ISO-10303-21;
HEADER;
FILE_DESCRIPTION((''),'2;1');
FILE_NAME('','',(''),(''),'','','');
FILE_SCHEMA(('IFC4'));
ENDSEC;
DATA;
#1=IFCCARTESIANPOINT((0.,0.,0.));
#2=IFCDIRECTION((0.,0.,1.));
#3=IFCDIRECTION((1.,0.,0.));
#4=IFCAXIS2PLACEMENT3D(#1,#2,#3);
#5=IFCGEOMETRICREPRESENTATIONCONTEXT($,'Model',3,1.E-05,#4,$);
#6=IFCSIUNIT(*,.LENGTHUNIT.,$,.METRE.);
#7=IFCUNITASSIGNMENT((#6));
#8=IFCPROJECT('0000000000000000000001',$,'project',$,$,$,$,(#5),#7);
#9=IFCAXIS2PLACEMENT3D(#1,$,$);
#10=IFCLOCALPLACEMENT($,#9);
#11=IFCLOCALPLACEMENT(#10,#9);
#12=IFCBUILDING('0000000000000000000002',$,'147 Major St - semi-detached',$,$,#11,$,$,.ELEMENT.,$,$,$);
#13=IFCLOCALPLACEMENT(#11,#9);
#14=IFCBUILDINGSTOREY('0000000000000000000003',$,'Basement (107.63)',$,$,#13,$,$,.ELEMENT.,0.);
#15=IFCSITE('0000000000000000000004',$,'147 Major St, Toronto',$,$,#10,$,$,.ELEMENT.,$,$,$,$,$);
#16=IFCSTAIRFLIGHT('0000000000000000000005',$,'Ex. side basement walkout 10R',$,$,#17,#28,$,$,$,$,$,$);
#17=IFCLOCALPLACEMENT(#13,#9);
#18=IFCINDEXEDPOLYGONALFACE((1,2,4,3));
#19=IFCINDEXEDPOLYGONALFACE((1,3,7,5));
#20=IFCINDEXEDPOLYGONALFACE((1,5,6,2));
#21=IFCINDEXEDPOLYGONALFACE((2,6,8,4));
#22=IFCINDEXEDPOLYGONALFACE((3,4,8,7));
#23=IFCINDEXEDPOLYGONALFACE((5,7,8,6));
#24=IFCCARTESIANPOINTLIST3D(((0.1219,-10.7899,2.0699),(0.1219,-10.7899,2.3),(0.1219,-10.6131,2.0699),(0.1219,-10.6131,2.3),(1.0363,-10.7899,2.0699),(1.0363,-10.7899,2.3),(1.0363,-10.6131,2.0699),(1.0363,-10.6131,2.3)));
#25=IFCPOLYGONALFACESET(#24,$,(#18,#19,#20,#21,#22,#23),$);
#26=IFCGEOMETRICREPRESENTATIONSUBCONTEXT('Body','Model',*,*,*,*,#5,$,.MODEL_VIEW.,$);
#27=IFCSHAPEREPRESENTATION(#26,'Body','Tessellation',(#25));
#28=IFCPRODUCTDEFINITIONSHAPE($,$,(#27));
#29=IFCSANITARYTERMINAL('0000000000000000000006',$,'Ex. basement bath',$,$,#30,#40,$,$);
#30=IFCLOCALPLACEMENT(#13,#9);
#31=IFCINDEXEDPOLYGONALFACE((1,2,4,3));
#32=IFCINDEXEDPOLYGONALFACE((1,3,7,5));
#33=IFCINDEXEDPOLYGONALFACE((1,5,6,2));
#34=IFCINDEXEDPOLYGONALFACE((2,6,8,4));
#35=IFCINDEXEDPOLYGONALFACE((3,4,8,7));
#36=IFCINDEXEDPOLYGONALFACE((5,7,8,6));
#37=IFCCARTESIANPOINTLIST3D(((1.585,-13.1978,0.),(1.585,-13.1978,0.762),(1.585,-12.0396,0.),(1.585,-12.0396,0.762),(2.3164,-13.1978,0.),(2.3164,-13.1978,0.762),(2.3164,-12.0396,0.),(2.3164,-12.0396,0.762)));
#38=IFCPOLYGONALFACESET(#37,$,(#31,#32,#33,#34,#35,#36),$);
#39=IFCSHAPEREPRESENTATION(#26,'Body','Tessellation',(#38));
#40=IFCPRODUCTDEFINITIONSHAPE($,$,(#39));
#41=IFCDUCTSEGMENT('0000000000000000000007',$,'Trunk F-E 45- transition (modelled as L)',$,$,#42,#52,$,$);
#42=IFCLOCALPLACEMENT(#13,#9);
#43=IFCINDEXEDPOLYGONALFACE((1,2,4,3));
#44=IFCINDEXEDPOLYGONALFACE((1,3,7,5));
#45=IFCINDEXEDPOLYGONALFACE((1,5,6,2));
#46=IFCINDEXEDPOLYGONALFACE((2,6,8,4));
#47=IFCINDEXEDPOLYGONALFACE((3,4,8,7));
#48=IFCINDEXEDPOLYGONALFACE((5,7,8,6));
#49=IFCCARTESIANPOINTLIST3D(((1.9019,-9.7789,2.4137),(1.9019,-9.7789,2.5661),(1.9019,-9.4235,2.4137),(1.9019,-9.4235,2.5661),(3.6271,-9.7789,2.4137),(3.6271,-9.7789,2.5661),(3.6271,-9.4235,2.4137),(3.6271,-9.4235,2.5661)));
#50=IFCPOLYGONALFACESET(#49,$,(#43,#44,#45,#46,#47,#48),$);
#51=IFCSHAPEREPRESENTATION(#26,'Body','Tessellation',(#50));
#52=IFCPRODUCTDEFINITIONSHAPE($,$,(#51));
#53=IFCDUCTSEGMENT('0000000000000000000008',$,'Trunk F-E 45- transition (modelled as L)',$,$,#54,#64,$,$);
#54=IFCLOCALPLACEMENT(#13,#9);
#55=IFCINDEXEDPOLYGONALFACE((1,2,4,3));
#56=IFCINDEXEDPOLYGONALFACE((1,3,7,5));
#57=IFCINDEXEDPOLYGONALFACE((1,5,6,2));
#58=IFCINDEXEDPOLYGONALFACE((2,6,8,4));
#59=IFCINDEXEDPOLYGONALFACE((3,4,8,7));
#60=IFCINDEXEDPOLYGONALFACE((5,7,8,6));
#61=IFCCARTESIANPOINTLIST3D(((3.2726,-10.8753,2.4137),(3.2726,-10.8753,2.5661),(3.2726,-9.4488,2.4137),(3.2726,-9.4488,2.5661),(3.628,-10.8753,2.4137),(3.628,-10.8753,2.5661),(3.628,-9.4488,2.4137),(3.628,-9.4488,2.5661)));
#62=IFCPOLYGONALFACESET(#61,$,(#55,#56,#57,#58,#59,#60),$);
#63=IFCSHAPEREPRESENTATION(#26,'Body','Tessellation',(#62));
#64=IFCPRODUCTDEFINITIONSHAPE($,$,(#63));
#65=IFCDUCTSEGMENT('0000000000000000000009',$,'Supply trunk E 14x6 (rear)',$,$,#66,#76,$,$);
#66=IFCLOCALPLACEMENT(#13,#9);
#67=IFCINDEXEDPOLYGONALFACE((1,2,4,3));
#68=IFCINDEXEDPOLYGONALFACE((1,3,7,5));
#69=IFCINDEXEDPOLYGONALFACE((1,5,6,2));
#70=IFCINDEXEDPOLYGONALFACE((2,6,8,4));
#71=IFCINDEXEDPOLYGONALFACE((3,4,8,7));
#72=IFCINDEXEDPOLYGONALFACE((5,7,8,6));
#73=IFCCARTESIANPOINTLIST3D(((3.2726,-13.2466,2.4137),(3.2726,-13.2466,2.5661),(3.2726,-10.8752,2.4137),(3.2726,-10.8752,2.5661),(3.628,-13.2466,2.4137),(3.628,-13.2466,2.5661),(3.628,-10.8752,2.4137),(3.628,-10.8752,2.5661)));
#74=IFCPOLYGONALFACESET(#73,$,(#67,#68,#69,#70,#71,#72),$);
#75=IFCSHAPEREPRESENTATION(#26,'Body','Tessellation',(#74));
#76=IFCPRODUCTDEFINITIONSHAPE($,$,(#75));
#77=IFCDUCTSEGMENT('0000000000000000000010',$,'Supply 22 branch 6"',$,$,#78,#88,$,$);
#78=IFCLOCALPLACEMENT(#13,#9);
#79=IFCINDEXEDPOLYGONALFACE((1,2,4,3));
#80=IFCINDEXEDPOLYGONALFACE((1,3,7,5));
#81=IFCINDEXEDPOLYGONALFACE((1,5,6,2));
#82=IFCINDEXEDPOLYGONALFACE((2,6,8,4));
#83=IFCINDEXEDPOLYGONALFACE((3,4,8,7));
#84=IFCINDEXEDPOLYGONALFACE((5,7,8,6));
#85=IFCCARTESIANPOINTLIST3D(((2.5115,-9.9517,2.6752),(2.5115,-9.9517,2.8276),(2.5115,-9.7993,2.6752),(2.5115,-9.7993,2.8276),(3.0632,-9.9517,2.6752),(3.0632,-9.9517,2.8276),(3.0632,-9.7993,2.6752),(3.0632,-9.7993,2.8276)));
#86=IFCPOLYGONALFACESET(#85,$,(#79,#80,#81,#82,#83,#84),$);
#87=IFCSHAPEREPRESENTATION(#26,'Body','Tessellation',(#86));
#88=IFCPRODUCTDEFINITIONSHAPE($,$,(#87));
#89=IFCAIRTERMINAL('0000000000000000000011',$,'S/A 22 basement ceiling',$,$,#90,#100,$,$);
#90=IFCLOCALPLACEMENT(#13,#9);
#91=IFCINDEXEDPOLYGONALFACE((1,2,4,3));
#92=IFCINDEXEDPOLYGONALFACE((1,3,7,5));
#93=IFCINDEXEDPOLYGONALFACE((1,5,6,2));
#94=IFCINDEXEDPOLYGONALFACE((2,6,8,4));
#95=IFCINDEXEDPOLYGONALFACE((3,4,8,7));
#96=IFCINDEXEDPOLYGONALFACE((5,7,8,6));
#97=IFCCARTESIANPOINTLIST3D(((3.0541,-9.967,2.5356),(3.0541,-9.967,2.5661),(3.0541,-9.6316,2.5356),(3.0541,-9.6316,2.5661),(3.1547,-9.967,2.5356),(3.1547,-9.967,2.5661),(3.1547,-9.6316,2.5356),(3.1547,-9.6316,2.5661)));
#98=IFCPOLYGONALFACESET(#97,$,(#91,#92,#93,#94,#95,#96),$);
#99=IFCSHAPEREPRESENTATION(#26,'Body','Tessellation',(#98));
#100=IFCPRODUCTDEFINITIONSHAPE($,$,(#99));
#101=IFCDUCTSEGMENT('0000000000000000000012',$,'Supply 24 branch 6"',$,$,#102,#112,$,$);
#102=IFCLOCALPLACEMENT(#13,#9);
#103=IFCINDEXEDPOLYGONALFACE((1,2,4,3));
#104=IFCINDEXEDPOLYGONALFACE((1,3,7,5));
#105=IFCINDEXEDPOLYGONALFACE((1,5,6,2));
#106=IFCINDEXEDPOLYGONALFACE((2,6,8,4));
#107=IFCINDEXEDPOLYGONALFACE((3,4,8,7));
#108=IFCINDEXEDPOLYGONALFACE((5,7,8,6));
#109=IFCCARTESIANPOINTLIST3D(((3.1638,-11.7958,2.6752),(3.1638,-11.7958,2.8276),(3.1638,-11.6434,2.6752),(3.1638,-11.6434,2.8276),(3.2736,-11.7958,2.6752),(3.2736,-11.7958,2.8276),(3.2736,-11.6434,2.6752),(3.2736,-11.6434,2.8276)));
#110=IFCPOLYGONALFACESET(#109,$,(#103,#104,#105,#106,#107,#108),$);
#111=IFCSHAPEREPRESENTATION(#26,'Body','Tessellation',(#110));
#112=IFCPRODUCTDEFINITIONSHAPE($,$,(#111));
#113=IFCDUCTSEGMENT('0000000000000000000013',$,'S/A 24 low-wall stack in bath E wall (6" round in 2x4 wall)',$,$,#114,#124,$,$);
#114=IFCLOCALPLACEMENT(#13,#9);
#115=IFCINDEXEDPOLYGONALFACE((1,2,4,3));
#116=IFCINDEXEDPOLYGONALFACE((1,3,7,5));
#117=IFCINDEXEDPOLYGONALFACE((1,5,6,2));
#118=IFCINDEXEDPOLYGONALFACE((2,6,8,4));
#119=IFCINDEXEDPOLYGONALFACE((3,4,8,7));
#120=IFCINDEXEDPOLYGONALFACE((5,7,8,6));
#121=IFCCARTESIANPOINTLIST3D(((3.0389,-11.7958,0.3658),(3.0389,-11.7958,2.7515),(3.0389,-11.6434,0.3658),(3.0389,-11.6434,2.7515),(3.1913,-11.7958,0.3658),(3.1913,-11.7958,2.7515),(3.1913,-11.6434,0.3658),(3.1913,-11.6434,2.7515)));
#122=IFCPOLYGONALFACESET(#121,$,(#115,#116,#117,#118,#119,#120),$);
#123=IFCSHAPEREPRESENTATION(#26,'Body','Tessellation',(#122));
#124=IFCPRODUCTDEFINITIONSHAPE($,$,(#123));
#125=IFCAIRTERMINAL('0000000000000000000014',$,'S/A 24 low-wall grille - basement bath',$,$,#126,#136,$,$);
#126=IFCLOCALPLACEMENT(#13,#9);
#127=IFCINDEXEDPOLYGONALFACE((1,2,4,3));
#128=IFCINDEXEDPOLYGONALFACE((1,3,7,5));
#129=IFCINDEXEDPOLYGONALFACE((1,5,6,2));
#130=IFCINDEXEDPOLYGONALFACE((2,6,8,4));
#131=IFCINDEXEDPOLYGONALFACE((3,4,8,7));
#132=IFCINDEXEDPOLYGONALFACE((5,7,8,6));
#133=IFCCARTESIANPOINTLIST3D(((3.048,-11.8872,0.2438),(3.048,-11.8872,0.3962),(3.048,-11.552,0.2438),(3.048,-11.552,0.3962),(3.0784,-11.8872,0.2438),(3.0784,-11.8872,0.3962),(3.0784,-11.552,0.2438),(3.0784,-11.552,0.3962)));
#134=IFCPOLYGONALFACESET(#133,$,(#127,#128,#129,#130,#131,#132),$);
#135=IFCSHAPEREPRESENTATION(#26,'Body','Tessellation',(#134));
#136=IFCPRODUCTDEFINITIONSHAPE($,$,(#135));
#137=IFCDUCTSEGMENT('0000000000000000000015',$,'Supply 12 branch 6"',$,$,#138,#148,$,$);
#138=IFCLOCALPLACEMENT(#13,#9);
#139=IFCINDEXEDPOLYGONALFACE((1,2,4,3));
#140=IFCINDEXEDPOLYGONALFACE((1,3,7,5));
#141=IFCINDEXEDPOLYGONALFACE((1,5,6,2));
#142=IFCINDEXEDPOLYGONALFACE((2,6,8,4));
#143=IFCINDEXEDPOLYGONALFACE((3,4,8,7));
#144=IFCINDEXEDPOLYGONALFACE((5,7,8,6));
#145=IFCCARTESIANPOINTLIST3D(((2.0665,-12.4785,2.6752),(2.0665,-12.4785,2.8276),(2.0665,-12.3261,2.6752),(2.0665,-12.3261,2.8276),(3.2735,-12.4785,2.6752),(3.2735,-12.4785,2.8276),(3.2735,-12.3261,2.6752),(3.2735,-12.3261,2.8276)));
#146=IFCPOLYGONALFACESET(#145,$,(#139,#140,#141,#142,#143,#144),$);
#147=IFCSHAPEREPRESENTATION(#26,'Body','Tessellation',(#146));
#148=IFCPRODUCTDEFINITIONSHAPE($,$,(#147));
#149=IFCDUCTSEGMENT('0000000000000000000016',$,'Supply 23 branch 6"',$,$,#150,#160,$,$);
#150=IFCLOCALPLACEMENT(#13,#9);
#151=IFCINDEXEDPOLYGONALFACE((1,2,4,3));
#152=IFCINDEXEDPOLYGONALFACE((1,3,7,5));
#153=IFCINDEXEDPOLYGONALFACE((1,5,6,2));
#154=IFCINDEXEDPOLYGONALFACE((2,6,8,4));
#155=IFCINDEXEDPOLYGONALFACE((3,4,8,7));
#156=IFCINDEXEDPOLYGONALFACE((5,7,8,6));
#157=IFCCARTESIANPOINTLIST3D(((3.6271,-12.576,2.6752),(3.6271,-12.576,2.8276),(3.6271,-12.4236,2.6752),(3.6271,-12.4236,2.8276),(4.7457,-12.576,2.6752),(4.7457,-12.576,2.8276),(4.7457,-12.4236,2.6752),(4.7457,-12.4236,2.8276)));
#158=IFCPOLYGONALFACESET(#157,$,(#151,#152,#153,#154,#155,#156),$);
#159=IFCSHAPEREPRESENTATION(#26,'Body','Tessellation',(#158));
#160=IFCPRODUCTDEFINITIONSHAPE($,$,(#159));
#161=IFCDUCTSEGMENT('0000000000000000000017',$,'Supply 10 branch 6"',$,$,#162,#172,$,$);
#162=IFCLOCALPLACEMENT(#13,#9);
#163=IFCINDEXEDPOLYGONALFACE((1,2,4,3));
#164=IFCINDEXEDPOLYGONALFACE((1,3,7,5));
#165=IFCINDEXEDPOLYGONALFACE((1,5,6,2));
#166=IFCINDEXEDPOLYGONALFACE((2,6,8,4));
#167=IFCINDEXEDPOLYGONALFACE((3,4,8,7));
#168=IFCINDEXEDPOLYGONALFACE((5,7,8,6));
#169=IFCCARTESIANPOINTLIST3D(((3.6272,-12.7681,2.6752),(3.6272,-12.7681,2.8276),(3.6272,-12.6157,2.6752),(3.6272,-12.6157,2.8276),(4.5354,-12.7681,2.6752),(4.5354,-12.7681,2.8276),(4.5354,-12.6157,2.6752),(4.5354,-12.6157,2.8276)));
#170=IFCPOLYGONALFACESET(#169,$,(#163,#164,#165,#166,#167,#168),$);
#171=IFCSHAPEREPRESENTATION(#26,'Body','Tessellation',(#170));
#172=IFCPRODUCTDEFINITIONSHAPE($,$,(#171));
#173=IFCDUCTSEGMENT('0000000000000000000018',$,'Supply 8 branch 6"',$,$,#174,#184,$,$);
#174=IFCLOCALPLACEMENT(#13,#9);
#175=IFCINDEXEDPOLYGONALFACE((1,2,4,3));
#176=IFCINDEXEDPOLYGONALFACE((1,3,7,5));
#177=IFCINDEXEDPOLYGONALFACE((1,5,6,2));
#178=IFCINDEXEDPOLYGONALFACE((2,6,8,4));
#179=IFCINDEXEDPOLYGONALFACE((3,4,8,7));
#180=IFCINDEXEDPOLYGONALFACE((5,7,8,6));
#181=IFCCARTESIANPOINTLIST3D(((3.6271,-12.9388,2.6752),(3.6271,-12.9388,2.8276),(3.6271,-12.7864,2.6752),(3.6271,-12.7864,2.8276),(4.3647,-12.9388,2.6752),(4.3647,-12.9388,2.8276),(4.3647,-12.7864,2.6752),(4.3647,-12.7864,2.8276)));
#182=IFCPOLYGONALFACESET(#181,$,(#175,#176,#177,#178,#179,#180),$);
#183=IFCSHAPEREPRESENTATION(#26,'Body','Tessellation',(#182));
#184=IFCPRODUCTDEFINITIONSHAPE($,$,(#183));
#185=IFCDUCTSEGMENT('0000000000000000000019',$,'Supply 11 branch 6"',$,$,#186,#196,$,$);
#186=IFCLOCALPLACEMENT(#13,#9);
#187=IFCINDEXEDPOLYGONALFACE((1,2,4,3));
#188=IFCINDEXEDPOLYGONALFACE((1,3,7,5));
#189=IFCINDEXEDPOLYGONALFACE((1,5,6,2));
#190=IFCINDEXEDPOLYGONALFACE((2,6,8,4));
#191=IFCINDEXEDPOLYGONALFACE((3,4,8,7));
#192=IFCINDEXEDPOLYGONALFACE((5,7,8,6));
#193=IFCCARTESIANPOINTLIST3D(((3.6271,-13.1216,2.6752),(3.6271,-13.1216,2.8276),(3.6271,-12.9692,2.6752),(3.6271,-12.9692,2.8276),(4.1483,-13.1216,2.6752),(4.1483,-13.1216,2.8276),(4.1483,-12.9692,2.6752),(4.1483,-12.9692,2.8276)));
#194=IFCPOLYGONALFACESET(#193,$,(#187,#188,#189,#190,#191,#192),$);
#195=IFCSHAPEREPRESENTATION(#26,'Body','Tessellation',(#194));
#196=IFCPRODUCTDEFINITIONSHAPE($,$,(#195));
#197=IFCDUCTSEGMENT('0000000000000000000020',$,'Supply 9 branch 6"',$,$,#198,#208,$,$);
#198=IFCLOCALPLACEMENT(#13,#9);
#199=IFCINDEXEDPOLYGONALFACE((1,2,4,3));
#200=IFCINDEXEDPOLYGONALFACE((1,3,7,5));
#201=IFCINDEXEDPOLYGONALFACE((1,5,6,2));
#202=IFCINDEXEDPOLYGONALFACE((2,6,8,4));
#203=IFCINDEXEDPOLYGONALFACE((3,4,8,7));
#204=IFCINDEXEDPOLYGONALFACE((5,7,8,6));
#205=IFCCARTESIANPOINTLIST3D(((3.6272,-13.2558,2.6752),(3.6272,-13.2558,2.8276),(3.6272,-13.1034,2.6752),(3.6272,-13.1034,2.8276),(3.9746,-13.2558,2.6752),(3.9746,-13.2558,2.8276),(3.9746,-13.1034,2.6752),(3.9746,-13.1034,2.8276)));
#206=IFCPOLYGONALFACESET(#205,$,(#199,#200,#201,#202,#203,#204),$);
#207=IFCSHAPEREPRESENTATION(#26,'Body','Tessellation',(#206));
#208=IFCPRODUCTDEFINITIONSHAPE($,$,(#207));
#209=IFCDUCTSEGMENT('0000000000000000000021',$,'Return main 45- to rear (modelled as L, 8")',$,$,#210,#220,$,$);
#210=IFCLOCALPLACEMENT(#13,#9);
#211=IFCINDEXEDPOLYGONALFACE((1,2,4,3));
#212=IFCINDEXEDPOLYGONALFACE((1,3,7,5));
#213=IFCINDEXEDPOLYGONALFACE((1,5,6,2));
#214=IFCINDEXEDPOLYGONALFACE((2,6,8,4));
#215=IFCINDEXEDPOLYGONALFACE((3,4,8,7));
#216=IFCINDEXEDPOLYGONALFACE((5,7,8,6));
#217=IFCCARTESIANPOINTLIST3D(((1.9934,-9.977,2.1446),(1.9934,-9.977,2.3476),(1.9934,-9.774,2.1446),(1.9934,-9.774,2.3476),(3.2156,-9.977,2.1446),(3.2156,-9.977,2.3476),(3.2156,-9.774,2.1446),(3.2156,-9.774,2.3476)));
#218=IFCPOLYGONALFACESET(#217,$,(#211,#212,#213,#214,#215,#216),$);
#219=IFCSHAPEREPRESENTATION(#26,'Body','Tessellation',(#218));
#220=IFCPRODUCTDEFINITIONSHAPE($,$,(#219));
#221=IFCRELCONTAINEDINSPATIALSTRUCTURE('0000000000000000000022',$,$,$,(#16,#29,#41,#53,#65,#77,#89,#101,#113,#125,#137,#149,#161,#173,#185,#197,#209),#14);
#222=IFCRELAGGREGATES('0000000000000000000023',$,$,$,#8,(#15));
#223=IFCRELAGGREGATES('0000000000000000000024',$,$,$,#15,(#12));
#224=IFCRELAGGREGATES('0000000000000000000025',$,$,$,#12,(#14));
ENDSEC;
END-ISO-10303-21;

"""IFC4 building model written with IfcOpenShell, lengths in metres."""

from ifc_helpers import new_model, si_unit, frame, origin, origin_with_axes, place, context, subcontext, project, spatial, rectangle, extrude, element, save


model = new_model("IFC4")

# Units and contexts
model_context = context("Model", 3, precision=1e-05, world=origin_with_axes())
body_context = subcontext(model_context, "Body", "Model", "MODEL_VIEW")
ifc_project = project(units=[si_unit("LENGTHUNIT", "METRE")], contexts=[model_context])

# Site, building, storey
site_placement = place(None, origin())
site = spatial("IfcSite", under=ifc_project, at=site_placement, Name="147 Major St, Toronto", CompositionType="ELEMENT")
building_placement = place(site_placement, origin())
building = spatial("IfcBuilding", under=site, at=building_placement, Name="147 Major St - semi-detached", CompositionType="ELEMENT")
storey_placement = place(building_placement, origin())
storey = spatial("IfcBuildingStorey", under=building, at=storey_placement, Name="Basement (107.63)", CompositionType="ELEMENT", Elevation=0.0)

# Stair flight
stair_flight_1_placement = place(storey_placement, frame((0.5791, -10.7015, 2.0699)))
element("IfcStairFlight", 1, at=stair_flight_1_placement, inside=storey, Name="Ex. side basement walkout 10R", context=body_context, shape_type="SweptSolid", body=[
    extrude(rectangle(XDim=0.9144, YDim=0.1768), origin_with_axes(), (0.0, 0.0, 1.0), 0.2301),
])

# Sanitary terminal
sanitary_terminal_placement = place(storey_placement, frame((1.9507, -12.6187, 0.0)))
element("IfcSanitaryTerminal", 2, at=sanitary_terminal_placement, inside=storey, Name="Ex. basement bath", context=body_context, shape_type="SweptSolid", body=[
    extrude(rectangle(XDim=0.7315, YDim=1.1582), origin_with_axes(), (0.0, 0.0, 1.0), 0.762),
])

# Duct segments
duct_segment_1_placement = place(storey_placement, frame((2.7645, -9.6012, 2.4137)))
element("IfcDuctSegment", 3, at=duct_segment_1_placement, inside=storey, Name="Trunk F-E 45- transition (modelled as L)", context=body_context, shape_type="SweptSolid", body=[
    extrude(rectangle(XDim=1.7252, YDim=0.3554), origin_with_axes(), (0.0, 0.0, 1.0), 0.1524),
])
duct_segment_2_placement = place(storey_placement, frame((3.4503, -10.162, 2.4137)))
element("IfcDuctSegment", 4, at=duct_segment_2_placement, inside=storey, Name="Trunk F-E 45- transition (modelled as L)", context=body_context, shape_type="SweptSolid", body=[
    extrude(rectangle(XDim=0.3554, YDim=1.4265), origin_with_axes(), (0.0, 0.0, 1.0), 0.1524),
])
duct_segment_3_placement = place(storey_placement, frame((3.4503, -12.0609, 2.4137)))
element("IfcDuctSegment", 5, at=duct_segment_3_placement, inside=storey, Name="Supply trunk E 14x6 (rear)", context=body_context, shape_type="SweptSolid", body=[
    extrude(rectangle(XDim=0.3554, YDim=2.3713), origin_with_axes(), (0.0, 0.0, 1.0), 0.1524),
])
duct_segment_4_placement = place(storey_placement, frame((2.7874, -9.8755, 2.6752)))
element("IfcDuctSegment", 6, at=duct_segment_4_placement, inside=storey, Name="Supply 22 branch 6\"", context=body_context, shape_type="SweptSolid", body=[
    extrude(rectangle(XDim=0.5517, YDim=0.1524), origin_with_axes(), (0.0, 0.0, 1.0), 0.1524),
])

# Air terminal
air_terminal_1_placement = place(storey_placement, frame((3.1044, -9.7993, 2.5356)))
element("IfcAirTerminal", 7, at=air_terminal_1_placement, inside=storey, Name="S/A 22 basement ceiling", context=body_context, shape_type="SweptSolid", body=[
    extrude(rectangle(XDim=0.1006, YDim=0.3353), origin_with_axes(), (0.0, 0.0, 1.0), 0.0305),
])

# Duct segments
duct_segment_5_placement = place(storey_placement, frame((3.2187, -11.7196, 2.6752)))
element("IfcDuctSegment", 8, at=duct_segment_5_placement, inside=storey, Name="Supply 24 branch 6\"", context=body_context, shape_type="SweptSolid", body=[
    extrude(rectangle(XDim=0.1097, YDim=0.1524), origin_with_axes(), (0.0, 0.0, 1.0), 0.1524),
])
duct_segment_6_placement = place(storey_placement, frame((3.1151, -11.7196, 0.3658)))
element("IfcDuctSegment", 9, at=duct_segment_6_placement, inside=storey, Name="S/A 24 low-wall stack in bath E wall (6\" round in 2x4 wall)", context=body_context, shape_type="SweptSolid", body=[
    extrude(rectangle(XDim=0.1524, YDim=0.1524), origin_with_axes(), (0.0, 0.0, 1.0), 2.3857),
])

# Air terminal
air_terminal_2_placement = place(storey_placement, frame((3.0632, -11.7196, 0.2438)))
element("IfcAirTerminal", 10, at=air_terminal_2_placement, inside=storey, Name="S/A 24 low-wall grille - basement bath", context=body_context, shape_type="SweptSolid", body=[
    extrude(rectangle(XDim=0.0305, YDim=0.3353), origin_with_axes(), (0.0, 0.0, 1.0), 0.1524),
])

# Duct segments
duct_segment_7_placement = place(storey_placement, frame((2.67, -12.4023, 2.6752)))
element("IfcDuctSegment", 11, at=duct_segment_7_placement, inside=storey, Name="Supply 12 branch 6\"", context=body_context, shape_type="SweptSolid", body=[
    extrude(rectangle(XDim=1.207, YDim=0.1524), origin_with_axes(), (0.0, 0.0, 1.0), 0.1524),
])
duct_segment_8_placement = place(storey_placement, frame((4.1864, -12.4998, 2.6752)))
element("IfcDuctSegment", 12, at=duct_segment_8_placement, inside=storey, Name="Supply 23 branch 6\"", context=body_context, shape_type="SweptSolid", body=[
    extrude(rectangle(XDim=1.1186, YDim=0.1524), origin_with_axes(), (0.0, 0.0, 1.0), 0.1524),
])
duct_segment_9_placement = place(storey_placement, frame((4.0813, -12.6919, 2.6752)))
element("IfcDuctSegment", 13, at=duct_segment_9_placement, inside=storey, Name="Supply 10 branch 6\"", context=body_context, shape_type="SweptSolid", body=[
    extrude(rectangle(XDim=0.9083, YDim=0.1524), origin_with_axes(), (0.0, 0.0, 1.0), 0.1524),
])
duct_segment_10_placement = place(storey_placement, frame((3.9959, -12.8626, 2.6752)))
element("IfcDuctSegment", 14, at=duct_segment_10_placement, inside=storey, Name="Supply 8 branch 6\"", context=body_context, shape_type="SweptSolid", body=[
    extrude(rectangle(XDim=0.7376, YDim=0.1524), origin_with_axes(), (0.0, 0.0, 1.0), 0.1524),
])
duct_segment_11_placement = place(storey_placement, frame((3.8877, -13.0454, 2.6752)))
element("IfcDuctSegment", 15, at=duct_segment_11_placement, inside=storey, Name="Supply 11 branch 6\"", context=body_context, shape_type="SweptSolid", body=[
    extrude(rectangle(XDim=0.5212, YDim=0.1524), origin_with_axes(), (0.0, 0.0, 1.0), 0.1524),
])
duct_segment_12_placement = place(storey_placement, frame((3.8009, -13.1796, 2.6752)))
element("IfcDuctSegment", 16, at=duct_segment_12_placement, inside=storey, Name="Supply 9 branch 6\"", context=body_context, shape_type="SweptSolid", body=[
    extrude(rectangle(XDim=0.3475, YDim=0.1524), origin_with_axes(), (0.0, 0.0, 1.0), 0.1524),
])
duct_segment_13_placement = place(storey_placement, frame((2.6045, -9.8755, 2.1446)))
element("IfcDuctSegment", 17, at=duct_segment_13_placement, inside=storey, Name="Return main 45- to rear (modelled as L, 8\")", context=body_context, shape_type="SweptSolid", body=[
    extrude(rectangle(XDim=1.2222, YDim=0.203), origin_with_axes(), (0.0, 0.0, 1.0), 0.203),
])

save(model, "model.ifc")
